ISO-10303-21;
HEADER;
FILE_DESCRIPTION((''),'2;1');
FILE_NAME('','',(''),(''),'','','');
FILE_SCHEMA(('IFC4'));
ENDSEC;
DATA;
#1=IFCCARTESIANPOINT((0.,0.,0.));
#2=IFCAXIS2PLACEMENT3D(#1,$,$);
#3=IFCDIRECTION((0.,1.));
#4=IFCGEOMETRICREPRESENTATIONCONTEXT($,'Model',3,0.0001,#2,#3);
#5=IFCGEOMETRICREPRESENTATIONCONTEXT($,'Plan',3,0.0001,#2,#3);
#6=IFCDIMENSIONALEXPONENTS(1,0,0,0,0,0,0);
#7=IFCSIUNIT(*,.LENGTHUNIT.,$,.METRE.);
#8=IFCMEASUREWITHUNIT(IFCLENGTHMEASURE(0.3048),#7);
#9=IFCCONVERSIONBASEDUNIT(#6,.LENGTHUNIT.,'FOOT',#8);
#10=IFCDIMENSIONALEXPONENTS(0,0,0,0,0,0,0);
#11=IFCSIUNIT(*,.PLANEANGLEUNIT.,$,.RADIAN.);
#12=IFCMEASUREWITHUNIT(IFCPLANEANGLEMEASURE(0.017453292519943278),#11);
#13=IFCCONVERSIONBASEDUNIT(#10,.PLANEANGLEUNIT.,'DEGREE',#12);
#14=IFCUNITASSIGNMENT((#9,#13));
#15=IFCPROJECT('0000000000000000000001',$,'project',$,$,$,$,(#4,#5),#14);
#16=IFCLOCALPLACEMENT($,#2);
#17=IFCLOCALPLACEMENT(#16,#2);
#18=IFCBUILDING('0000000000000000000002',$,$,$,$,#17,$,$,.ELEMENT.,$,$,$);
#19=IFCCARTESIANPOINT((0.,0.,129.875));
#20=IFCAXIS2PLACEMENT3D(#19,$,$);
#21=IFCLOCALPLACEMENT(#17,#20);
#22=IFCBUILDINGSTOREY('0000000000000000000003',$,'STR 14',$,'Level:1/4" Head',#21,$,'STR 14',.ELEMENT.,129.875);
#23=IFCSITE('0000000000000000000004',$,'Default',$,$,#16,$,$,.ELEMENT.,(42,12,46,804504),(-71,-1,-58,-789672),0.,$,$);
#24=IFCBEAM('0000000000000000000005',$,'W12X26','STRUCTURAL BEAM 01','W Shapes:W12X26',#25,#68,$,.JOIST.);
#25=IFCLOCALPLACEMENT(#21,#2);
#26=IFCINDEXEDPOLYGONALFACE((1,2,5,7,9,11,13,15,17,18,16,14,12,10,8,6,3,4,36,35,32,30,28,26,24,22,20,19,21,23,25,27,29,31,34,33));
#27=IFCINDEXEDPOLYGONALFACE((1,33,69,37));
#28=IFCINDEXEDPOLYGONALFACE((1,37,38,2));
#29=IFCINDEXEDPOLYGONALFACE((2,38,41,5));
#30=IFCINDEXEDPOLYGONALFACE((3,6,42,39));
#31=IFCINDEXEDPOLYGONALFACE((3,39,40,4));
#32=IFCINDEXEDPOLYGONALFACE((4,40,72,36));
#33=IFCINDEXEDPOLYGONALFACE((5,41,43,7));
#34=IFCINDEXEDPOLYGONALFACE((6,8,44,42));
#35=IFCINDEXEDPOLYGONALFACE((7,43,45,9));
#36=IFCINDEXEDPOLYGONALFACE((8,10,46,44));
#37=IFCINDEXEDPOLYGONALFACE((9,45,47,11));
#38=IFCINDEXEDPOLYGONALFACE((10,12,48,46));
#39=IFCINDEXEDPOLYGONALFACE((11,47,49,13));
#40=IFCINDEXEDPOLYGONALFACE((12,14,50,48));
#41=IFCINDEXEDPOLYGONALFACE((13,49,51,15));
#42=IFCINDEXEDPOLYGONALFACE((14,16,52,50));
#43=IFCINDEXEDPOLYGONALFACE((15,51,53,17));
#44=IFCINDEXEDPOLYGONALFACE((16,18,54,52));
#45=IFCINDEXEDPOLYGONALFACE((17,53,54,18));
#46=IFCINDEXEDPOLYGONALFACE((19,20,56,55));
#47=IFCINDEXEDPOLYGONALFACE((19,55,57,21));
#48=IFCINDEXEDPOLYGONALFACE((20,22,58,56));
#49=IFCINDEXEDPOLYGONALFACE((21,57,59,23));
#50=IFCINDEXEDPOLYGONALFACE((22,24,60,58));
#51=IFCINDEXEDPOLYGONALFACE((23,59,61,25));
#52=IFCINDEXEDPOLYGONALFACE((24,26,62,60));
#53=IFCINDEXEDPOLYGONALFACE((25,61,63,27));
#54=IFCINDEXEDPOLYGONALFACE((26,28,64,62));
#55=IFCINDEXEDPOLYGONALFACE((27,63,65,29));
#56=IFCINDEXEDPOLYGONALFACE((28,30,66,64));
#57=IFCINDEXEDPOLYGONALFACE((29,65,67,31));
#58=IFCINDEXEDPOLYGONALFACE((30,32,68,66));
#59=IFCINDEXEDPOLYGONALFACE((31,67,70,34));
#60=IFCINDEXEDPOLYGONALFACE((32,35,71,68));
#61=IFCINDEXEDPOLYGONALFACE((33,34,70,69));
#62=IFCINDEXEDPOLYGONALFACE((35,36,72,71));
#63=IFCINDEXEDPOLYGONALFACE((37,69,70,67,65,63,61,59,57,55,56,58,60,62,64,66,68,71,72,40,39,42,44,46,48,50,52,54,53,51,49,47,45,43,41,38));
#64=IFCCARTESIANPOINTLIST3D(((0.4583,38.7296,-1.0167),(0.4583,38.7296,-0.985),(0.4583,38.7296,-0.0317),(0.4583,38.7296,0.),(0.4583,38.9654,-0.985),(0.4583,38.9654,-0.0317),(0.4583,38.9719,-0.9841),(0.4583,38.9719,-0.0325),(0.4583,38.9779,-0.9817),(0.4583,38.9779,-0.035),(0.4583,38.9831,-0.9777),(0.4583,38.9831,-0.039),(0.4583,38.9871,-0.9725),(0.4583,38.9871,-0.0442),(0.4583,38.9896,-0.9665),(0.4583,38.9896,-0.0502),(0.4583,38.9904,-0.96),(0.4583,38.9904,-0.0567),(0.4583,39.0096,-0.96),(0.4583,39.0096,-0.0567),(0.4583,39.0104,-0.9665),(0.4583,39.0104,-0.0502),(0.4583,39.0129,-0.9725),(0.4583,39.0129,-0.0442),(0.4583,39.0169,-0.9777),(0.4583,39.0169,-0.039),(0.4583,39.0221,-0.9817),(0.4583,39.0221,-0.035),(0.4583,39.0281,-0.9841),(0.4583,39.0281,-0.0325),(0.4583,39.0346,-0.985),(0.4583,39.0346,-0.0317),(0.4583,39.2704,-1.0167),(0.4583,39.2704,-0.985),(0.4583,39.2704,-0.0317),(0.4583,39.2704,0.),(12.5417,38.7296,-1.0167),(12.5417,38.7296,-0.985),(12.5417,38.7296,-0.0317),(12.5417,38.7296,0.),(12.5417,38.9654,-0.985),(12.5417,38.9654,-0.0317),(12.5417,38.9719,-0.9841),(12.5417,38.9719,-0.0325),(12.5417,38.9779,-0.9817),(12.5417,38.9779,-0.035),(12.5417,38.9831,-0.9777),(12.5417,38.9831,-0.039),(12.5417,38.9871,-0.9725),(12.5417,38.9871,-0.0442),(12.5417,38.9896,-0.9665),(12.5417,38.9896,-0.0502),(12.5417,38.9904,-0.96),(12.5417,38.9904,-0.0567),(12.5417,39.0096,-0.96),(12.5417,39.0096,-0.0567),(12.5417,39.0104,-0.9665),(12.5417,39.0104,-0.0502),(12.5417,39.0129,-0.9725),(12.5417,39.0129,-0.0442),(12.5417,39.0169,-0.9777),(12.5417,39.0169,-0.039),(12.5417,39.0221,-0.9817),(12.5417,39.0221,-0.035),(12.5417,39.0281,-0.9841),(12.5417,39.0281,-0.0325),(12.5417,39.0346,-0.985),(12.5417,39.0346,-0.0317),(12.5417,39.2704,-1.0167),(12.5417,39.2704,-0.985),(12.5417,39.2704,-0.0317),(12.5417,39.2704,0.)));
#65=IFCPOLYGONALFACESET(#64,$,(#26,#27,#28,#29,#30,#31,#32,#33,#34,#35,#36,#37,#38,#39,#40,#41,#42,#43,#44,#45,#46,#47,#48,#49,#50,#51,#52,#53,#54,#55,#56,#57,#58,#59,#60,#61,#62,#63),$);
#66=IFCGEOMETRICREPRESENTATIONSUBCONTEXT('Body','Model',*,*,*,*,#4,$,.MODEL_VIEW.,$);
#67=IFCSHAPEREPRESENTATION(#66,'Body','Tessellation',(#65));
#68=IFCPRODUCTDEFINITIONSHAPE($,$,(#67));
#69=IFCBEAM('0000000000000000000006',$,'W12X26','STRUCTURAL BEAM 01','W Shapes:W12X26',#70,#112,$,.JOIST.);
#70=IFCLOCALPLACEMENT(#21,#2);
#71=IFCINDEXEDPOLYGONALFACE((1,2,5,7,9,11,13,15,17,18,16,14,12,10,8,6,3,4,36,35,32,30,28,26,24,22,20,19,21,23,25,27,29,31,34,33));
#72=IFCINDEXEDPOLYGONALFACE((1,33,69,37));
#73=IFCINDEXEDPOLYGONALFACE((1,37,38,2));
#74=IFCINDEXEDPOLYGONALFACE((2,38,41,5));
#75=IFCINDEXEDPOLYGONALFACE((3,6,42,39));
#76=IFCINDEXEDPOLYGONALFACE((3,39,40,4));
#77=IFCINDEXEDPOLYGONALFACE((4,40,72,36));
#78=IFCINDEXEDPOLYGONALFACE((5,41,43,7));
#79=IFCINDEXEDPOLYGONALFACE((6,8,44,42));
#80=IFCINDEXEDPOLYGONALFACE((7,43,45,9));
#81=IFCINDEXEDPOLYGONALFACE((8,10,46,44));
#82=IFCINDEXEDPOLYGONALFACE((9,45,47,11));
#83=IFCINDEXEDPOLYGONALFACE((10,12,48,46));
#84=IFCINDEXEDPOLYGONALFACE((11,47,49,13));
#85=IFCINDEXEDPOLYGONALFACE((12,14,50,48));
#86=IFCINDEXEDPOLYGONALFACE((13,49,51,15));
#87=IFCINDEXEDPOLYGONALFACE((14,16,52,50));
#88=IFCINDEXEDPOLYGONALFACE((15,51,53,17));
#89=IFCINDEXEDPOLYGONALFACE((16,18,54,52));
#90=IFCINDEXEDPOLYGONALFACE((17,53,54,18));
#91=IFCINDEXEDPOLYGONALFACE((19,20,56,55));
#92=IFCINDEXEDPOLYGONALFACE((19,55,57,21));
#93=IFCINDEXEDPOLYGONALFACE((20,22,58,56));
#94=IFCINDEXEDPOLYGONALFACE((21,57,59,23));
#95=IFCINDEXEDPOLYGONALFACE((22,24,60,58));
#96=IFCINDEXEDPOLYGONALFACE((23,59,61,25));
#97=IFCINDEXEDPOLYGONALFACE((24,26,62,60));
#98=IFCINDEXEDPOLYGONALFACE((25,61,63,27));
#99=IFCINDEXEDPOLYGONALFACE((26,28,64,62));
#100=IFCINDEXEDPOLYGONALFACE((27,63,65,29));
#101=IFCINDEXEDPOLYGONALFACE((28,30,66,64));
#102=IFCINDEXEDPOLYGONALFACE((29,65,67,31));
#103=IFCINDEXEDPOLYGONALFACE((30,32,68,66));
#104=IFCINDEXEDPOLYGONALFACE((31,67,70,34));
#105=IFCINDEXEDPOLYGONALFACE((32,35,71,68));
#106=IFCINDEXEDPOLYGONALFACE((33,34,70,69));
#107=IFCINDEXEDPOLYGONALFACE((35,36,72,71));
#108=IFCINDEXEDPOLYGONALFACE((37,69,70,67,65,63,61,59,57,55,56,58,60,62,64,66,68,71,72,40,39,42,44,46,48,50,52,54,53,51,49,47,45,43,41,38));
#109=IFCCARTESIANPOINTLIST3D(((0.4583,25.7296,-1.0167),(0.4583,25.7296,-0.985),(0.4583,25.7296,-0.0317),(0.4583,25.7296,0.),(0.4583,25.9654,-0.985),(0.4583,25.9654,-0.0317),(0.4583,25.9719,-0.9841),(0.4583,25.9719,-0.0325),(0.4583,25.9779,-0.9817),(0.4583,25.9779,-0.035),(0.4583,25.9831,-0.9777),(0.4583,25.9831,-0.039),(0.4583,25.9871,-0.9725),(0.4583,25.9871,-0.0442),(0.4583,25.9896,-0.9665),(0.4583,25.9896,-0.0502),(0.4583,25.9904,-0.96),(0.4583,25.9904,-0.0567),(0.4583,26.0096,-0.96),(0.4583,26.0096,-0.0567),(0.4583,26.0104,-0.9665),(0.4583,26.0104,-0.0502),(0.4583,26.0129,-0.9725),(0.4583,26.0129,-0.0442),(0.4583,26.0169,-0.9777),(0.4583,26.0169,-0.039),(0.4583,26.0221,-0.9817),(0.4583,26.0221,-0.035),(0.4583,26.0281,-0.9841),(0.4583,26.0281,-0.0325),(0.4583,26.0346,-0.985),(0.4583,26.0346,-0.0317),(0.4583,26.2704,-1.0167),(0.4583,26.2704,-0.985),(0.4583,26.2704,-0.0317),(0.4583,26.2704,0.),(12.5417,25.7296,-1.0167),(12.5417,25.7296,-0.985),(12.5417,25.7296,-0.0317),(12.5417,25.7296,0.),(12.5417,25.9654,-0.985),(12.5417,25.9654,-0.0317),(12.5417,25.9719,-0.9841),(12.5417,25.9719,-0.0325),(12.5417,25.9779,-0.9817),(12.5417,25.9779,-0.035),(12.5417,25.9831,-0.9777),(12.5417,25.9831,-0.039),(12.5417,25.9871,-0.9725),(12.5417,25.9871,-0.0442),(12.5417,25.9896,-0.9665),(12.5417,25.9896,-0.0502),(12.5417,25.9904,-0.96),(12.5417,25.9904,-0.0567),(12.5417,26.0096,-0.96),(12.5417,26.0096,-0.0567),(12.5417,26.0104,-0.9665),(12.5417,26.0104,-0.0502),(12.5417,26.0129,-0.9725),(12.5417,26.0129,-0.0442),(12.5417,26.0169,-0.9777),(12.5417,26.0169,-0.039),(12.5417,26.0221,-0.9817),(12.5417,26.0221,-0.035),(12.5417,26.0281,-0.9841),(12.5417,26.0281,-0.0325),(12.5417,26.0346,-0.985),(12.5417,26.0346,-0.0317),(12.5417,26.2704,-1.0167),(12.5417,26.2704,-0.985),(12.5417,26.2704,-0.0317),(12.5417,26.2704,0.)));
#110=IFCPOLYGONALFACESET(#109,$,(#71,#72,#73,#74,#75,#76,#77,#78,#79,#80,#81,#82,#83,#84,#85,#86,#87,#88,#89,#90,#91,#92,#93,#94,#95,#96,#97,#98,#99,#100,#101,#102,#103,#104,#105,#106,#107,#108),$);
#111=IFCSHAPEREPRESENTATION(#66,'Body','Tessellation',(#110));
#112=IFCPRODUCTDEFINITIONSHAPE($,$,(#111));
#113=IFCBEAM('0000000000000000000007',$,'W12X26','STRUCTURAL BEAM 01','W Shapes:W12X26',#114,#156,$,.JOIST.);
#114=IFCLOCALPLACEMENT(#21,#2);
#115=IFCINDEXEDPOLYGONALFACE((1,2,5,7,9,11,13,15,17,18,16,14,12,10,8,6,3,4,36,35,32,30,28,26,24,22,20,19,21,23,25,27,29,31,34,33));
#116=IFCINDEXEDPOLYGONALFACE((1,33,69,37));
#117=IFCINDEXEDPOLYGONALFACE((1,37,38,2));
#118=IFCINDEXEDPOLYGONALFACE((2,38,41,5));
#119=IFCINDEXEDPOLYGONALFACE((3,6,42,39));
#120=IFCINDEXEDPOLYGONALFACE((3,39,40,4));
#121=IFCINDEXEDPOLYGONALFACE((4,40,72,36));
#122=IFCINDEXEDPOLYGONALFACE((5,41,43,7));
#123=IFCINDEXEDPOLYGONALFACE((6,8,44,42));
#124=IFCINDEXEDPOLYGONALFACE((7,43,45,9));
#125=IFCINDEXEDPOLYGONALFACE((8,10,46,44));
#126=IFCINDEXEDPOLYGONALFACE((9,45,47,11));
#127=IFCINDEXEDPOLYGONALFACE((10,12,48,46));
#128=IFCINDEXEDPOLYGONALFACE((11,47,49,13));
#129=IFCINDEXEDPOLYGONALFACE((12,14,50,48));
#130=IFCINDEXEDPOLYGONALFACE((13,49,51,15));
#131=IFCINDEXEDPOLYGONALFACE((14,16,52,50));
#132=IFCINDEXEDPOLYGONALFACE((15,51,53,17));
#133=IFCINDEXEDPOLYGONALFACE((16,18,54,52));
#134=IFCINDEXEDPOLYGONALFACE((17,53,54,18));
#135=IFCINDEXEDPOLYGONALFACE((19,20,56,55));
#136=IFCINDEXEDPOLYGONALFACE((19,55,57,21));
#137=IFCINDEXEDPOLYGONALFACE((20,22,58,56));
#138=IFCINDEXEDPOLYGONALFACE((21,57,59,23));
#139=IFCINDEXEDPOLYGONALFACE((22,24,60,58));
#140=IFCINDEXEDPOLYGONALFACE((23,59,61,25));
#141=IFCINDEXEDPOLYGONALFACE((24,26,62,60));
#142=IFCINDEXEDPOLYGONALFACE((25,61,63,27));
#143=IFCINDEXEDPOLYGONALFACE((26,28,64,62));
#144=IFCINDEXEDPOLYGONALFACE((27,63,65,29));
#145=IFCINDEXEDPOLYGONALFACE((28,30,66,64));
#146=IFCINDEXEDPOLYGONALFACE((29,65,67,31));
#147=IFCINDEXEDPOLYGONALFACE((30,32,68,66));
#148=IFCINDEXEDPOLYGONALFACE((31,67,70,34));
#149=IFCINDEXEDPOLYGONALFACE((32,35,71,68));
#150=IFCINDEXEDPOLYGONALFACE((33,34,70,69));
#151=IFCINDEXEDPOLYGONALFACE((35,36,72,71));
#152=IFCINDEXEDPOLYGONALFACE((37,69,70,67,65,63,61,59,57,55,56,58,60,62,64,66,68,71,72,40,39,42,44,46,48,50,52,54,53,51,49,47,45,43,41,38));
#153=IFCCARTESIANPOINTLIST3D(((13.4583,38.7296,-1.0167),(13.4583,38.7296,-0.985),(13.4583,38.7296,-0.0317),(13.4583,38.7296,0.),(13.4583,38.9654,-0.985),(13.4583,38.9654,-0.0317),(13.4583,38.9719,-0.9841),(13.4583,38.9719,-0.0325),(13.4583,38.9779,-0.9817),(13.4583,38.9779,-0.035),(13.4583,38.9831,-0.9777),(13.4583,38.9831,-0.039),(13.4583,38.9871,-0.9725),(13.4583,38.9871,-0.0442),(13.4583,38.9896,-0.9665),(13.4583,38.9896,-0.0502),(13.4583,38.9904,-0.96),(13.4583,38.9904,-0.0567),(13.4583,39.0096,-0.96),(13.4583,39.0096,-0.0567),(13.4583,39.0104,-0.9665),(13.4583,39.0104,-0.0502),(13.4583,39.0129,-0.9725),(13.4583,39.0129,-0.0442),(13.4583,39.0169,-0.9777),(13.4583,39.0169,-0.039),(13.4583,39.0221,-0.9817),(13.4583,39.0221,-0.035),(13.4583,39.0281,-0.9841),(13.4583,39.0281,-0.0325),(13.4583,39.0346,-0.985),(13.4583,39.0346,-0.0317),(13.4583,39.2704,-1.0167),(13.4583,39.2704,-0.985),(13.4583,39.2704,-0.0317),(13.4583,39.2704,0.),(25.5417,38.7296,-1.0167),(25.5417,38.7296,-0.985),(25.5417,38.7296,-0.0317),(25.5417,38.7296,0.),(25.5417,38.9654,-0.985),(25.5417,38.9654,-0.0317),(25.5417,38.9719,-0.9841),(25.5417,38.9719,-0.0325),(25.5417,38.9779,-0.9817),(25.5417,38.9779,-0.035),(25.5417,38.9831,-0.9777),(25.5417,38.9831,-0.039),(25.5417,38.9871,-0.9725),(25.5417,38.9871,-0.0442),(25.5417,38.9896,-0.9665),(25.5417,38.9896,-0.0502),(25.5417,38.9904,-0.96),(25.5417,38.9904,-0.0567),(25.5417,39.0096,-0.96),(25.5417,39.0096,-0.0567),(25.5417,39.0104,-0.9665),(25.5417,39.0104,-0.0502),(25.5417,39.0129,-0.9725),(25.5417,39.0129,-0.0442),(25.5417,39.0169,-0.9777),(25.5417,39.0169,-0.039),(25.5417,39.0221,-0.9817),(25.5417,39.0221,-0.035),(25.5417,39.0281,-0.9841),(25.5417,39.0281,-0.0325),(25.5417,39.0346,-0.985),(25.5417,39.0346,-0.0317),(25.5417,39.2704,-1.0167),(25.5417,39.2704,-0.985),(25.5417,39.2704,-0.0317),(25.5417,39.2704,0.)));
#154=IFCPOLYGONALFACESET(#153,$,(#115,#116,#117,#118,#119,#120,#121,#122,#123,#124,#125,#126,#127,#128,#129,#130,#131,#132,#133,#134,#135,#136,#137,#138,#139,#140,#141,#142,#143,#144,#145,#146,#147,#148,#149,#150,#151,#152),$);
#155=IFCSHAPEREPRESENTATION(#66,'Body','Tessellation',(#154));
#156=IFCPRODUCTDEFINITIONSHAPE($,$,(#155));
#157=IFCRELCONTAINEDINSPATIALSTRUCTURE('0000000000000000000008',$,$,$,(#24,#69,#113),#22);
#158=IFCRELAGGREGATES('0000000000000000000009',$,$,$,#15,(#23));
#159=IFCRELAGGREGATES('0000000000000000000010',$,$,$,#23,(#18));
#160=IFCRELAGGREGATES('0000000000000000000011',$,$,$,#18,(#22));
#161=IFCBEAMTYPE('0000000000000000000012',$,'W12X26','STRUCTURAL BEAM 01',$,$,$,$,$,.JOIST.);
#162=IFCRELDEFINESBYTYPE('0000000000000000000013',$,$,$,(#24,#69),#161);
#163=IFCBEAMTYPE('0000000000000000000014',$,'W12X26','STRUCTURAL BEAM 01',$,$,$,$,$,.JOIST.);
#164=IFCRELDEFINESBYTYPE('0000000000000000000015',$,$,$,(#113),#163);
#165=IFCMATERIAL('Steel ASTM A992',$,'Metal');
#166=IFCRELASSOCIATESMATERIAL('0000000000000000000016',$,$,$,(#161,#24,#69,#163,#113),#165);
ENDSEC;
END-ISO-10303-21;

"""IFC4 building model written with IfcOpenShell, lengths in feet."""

from ifc_helpers import new_model, entity, si_unit, converted_unit, direction, frame, origin, place, context, subcontext, project, spatial, line, arc, indexed_curve, outline, extrude, source, transform, mapped, material, type_object, type_shapes, element, save


model = new_model("IFC4")

# Units and contexts
model_context = context("Model", 3, precision=0.0001, world=origin(), true_north=direction((0.0, 1.0)))
plan_context = context("Plan", 3, precision=0.0001, world=origin(), true_north=direction((0.0, 1.0)))
body_context = subcontext(model_context, "Body", "Model", "MODEL_VIEW")
ifc_project = project(units=[converted_unit("LENGTHUNIT", "FOOT", entity("IfcLengthMeasure", 0.3048), si_unit("LENGTHUNIT", "METRE"), dimensions=[1, 0, 0, 0, 0, 0, 0]), converted_unit("PLANEANGLEUNIT", "DEGREE", entity("IfcPlaneAngleMeasure", 0.017453292519943278), si_unit("PLANEANGLEUNIT", "RADIAN"), dimensions=[0, 0, 0, 0, 0, 0, 0])], contexts=[model_context, plan_context])

# Site, building, storey
site_placement = place(None, origin())
site = spatial("IfcSite", under=ifc_project, at=site_placement, Name="Default", CompositionType="ELEMENT", RefLatitude=(42, 12, 46, 804504), RefLongitude=(-71, -1, -58, -789672), RefElevation=0.0)
building_placement = place(site_placement, origin())
building = spatial("IfcBuilding", under=site, at=building_placement, CompositionType="ELEMENT")
storey_placement = place(building_placement, frame((0.0, 0.0, 129.875)))
storey = spatial("IfcBuildingStorey", under=building, at=storey_placement, Name="STR 14", ObjectType="Level:1/4\" Head", LongName="STR 14", CompositionType="ELEMENT", Elevation=129.875)

# Shared definitions
ifc_material = material(Name="Steel ASTM A992", Category="Metal")

# Beams
beam_type_1 = type_object("IfcBeamType", Name="W12X26", Description="STRUCTURAL BEAM 01", PredefinedType="JOIST", material=ifc_material)
shared_shape_1 = source(origin(), body_context, "Body", "SweptSolid", [
    extrude(outline(indexed_curve([(-0.2704, -0.4767), (-0.2704, -0.5083), (0.2704, -0.5083), (0.2704, -0.4767), (0.0346, -0.4767), (0.0169, -0.4693), (0.0096, -0.4517), (0.0096, 0.4517), (0.0169, 0.4693), (0.0346, 0.4767), (0.2704, 0.4767), (0.2704, 0.5083), (-0.2704, 0.5083), (-0.2704, 0.4767), (-0.0346, 0.4767), (-0.0169, 0.4693), (-0.0096, 0.4517), (-0.0096, -0.4517), (-0.0169, -0.4693), (-0.0346, -0.4767)], segments=[line(1, 2, 3, 4, 5), arc(5, 6, 7), line(7, 8), arc(8, 9, 10), line(10, 11, 12, 13, 14, 15), arc(15, 16, 17), line(17, 18), arc(18, 19, 20), line(20, 1)], self_intersect=False)), frame((-6.0465, 0.0, 0.0), z_axis=(-1.0, 0.0, 0.0), x_axis=(0.0, -1.0, 0.0)), (0.0, 0.0, -1.0), 12.0833),
])
type_shapes(beam_type_1, [shared_shape_1])
for number, where, name in (
    (1, (6.5048, 39.0, -0.5083), "W12X26"),
    (2, (6.5048, 26.0, -0.5083), "W12X26"),
):
    element("IfcBeam", number, at=place(storey_placement, frame(where)), inside=storey, type_object=beam_type_1, material=ifc_material, Name=name, Description="STRUCTURAL BEAM 01", ObjectType="W Shapes:W12X26", PredefinedType="JOIST", context=body_context, shape_type="MappedRepresentation", body=[
        mapped(shared_shape_1, transform((0.0, 0.0, 0.0), scale=1.0)),
    ])
beam_type_2 = type_object("IfcBeamType", Name="W12X26", Description="STRUCTURAL BEAM 01", PredefinedType="JOIST", material=ifc_material)
shared_shape_2 = source(origin(), body_context, "Body", "SweptSolid", [
    extrude(outline(indexed_curve([(-0.2704, -0.4767), (-0.2704, -0.5083), (0.2704, -0.5083), (0.2704, -0.4767), (0.0346, -0.4767), (0.0169, -0.4693), (0.0096, -0.4517), (0.0096, 0.4517), (0.0169, 0.4693), (0.0346, 0.4767), (0.2704, 0.4767), (0.2704, 0.5083), (-0.2704, 0.5083), (-0.2704, 0.4767), (-0.0346, 0.4767), (-0.0169, 0.4693), (-0.0096, 0.4517), (-0.0096, -0.4517), (-0.0169, -0.4693), (-0.0346, -0.4767)], segments=[line(1, 2, 3, 4, 5), arc(5, 6, 7), line(7, 8), arc(8, 9, 10), line(10, 11, 12, 13, 14, 15), arc(15, 16, 17), line(17, 18), arc(18, 19, 20), line(20, 1)], self_intersect=False)), frame((-6.0512, 0.0, 0.0), z_axis=(-1.0, 0.0, 0.0), x_axis=(0.0, -1.0, 0.0)), (0.0, 0.0, -1.0), 12.0833),
])
type_shapes(beam_type_2, [shared_shape_2])
for number, where, name in (
    (3, (19.5096, 39.0, -0.5083), "W12X26"),
):
    element("IfcBeam", number, at=place(storey_placement, frame(where)), inside=storey, type_object=beam_type_2, material=ifc_material, Name=name, Description="STRUCTURAL BEAM 01", ObjectType="W Shapes:W12X26", PredefinedType="JOIST", context=body_context, shape_type="MappedRepresentation", body=[
        mapped(shared_shape_2, transform((0.0, 0.0, 0.0), scale=1.0)),
    ])

save(model, "model.ifc")
